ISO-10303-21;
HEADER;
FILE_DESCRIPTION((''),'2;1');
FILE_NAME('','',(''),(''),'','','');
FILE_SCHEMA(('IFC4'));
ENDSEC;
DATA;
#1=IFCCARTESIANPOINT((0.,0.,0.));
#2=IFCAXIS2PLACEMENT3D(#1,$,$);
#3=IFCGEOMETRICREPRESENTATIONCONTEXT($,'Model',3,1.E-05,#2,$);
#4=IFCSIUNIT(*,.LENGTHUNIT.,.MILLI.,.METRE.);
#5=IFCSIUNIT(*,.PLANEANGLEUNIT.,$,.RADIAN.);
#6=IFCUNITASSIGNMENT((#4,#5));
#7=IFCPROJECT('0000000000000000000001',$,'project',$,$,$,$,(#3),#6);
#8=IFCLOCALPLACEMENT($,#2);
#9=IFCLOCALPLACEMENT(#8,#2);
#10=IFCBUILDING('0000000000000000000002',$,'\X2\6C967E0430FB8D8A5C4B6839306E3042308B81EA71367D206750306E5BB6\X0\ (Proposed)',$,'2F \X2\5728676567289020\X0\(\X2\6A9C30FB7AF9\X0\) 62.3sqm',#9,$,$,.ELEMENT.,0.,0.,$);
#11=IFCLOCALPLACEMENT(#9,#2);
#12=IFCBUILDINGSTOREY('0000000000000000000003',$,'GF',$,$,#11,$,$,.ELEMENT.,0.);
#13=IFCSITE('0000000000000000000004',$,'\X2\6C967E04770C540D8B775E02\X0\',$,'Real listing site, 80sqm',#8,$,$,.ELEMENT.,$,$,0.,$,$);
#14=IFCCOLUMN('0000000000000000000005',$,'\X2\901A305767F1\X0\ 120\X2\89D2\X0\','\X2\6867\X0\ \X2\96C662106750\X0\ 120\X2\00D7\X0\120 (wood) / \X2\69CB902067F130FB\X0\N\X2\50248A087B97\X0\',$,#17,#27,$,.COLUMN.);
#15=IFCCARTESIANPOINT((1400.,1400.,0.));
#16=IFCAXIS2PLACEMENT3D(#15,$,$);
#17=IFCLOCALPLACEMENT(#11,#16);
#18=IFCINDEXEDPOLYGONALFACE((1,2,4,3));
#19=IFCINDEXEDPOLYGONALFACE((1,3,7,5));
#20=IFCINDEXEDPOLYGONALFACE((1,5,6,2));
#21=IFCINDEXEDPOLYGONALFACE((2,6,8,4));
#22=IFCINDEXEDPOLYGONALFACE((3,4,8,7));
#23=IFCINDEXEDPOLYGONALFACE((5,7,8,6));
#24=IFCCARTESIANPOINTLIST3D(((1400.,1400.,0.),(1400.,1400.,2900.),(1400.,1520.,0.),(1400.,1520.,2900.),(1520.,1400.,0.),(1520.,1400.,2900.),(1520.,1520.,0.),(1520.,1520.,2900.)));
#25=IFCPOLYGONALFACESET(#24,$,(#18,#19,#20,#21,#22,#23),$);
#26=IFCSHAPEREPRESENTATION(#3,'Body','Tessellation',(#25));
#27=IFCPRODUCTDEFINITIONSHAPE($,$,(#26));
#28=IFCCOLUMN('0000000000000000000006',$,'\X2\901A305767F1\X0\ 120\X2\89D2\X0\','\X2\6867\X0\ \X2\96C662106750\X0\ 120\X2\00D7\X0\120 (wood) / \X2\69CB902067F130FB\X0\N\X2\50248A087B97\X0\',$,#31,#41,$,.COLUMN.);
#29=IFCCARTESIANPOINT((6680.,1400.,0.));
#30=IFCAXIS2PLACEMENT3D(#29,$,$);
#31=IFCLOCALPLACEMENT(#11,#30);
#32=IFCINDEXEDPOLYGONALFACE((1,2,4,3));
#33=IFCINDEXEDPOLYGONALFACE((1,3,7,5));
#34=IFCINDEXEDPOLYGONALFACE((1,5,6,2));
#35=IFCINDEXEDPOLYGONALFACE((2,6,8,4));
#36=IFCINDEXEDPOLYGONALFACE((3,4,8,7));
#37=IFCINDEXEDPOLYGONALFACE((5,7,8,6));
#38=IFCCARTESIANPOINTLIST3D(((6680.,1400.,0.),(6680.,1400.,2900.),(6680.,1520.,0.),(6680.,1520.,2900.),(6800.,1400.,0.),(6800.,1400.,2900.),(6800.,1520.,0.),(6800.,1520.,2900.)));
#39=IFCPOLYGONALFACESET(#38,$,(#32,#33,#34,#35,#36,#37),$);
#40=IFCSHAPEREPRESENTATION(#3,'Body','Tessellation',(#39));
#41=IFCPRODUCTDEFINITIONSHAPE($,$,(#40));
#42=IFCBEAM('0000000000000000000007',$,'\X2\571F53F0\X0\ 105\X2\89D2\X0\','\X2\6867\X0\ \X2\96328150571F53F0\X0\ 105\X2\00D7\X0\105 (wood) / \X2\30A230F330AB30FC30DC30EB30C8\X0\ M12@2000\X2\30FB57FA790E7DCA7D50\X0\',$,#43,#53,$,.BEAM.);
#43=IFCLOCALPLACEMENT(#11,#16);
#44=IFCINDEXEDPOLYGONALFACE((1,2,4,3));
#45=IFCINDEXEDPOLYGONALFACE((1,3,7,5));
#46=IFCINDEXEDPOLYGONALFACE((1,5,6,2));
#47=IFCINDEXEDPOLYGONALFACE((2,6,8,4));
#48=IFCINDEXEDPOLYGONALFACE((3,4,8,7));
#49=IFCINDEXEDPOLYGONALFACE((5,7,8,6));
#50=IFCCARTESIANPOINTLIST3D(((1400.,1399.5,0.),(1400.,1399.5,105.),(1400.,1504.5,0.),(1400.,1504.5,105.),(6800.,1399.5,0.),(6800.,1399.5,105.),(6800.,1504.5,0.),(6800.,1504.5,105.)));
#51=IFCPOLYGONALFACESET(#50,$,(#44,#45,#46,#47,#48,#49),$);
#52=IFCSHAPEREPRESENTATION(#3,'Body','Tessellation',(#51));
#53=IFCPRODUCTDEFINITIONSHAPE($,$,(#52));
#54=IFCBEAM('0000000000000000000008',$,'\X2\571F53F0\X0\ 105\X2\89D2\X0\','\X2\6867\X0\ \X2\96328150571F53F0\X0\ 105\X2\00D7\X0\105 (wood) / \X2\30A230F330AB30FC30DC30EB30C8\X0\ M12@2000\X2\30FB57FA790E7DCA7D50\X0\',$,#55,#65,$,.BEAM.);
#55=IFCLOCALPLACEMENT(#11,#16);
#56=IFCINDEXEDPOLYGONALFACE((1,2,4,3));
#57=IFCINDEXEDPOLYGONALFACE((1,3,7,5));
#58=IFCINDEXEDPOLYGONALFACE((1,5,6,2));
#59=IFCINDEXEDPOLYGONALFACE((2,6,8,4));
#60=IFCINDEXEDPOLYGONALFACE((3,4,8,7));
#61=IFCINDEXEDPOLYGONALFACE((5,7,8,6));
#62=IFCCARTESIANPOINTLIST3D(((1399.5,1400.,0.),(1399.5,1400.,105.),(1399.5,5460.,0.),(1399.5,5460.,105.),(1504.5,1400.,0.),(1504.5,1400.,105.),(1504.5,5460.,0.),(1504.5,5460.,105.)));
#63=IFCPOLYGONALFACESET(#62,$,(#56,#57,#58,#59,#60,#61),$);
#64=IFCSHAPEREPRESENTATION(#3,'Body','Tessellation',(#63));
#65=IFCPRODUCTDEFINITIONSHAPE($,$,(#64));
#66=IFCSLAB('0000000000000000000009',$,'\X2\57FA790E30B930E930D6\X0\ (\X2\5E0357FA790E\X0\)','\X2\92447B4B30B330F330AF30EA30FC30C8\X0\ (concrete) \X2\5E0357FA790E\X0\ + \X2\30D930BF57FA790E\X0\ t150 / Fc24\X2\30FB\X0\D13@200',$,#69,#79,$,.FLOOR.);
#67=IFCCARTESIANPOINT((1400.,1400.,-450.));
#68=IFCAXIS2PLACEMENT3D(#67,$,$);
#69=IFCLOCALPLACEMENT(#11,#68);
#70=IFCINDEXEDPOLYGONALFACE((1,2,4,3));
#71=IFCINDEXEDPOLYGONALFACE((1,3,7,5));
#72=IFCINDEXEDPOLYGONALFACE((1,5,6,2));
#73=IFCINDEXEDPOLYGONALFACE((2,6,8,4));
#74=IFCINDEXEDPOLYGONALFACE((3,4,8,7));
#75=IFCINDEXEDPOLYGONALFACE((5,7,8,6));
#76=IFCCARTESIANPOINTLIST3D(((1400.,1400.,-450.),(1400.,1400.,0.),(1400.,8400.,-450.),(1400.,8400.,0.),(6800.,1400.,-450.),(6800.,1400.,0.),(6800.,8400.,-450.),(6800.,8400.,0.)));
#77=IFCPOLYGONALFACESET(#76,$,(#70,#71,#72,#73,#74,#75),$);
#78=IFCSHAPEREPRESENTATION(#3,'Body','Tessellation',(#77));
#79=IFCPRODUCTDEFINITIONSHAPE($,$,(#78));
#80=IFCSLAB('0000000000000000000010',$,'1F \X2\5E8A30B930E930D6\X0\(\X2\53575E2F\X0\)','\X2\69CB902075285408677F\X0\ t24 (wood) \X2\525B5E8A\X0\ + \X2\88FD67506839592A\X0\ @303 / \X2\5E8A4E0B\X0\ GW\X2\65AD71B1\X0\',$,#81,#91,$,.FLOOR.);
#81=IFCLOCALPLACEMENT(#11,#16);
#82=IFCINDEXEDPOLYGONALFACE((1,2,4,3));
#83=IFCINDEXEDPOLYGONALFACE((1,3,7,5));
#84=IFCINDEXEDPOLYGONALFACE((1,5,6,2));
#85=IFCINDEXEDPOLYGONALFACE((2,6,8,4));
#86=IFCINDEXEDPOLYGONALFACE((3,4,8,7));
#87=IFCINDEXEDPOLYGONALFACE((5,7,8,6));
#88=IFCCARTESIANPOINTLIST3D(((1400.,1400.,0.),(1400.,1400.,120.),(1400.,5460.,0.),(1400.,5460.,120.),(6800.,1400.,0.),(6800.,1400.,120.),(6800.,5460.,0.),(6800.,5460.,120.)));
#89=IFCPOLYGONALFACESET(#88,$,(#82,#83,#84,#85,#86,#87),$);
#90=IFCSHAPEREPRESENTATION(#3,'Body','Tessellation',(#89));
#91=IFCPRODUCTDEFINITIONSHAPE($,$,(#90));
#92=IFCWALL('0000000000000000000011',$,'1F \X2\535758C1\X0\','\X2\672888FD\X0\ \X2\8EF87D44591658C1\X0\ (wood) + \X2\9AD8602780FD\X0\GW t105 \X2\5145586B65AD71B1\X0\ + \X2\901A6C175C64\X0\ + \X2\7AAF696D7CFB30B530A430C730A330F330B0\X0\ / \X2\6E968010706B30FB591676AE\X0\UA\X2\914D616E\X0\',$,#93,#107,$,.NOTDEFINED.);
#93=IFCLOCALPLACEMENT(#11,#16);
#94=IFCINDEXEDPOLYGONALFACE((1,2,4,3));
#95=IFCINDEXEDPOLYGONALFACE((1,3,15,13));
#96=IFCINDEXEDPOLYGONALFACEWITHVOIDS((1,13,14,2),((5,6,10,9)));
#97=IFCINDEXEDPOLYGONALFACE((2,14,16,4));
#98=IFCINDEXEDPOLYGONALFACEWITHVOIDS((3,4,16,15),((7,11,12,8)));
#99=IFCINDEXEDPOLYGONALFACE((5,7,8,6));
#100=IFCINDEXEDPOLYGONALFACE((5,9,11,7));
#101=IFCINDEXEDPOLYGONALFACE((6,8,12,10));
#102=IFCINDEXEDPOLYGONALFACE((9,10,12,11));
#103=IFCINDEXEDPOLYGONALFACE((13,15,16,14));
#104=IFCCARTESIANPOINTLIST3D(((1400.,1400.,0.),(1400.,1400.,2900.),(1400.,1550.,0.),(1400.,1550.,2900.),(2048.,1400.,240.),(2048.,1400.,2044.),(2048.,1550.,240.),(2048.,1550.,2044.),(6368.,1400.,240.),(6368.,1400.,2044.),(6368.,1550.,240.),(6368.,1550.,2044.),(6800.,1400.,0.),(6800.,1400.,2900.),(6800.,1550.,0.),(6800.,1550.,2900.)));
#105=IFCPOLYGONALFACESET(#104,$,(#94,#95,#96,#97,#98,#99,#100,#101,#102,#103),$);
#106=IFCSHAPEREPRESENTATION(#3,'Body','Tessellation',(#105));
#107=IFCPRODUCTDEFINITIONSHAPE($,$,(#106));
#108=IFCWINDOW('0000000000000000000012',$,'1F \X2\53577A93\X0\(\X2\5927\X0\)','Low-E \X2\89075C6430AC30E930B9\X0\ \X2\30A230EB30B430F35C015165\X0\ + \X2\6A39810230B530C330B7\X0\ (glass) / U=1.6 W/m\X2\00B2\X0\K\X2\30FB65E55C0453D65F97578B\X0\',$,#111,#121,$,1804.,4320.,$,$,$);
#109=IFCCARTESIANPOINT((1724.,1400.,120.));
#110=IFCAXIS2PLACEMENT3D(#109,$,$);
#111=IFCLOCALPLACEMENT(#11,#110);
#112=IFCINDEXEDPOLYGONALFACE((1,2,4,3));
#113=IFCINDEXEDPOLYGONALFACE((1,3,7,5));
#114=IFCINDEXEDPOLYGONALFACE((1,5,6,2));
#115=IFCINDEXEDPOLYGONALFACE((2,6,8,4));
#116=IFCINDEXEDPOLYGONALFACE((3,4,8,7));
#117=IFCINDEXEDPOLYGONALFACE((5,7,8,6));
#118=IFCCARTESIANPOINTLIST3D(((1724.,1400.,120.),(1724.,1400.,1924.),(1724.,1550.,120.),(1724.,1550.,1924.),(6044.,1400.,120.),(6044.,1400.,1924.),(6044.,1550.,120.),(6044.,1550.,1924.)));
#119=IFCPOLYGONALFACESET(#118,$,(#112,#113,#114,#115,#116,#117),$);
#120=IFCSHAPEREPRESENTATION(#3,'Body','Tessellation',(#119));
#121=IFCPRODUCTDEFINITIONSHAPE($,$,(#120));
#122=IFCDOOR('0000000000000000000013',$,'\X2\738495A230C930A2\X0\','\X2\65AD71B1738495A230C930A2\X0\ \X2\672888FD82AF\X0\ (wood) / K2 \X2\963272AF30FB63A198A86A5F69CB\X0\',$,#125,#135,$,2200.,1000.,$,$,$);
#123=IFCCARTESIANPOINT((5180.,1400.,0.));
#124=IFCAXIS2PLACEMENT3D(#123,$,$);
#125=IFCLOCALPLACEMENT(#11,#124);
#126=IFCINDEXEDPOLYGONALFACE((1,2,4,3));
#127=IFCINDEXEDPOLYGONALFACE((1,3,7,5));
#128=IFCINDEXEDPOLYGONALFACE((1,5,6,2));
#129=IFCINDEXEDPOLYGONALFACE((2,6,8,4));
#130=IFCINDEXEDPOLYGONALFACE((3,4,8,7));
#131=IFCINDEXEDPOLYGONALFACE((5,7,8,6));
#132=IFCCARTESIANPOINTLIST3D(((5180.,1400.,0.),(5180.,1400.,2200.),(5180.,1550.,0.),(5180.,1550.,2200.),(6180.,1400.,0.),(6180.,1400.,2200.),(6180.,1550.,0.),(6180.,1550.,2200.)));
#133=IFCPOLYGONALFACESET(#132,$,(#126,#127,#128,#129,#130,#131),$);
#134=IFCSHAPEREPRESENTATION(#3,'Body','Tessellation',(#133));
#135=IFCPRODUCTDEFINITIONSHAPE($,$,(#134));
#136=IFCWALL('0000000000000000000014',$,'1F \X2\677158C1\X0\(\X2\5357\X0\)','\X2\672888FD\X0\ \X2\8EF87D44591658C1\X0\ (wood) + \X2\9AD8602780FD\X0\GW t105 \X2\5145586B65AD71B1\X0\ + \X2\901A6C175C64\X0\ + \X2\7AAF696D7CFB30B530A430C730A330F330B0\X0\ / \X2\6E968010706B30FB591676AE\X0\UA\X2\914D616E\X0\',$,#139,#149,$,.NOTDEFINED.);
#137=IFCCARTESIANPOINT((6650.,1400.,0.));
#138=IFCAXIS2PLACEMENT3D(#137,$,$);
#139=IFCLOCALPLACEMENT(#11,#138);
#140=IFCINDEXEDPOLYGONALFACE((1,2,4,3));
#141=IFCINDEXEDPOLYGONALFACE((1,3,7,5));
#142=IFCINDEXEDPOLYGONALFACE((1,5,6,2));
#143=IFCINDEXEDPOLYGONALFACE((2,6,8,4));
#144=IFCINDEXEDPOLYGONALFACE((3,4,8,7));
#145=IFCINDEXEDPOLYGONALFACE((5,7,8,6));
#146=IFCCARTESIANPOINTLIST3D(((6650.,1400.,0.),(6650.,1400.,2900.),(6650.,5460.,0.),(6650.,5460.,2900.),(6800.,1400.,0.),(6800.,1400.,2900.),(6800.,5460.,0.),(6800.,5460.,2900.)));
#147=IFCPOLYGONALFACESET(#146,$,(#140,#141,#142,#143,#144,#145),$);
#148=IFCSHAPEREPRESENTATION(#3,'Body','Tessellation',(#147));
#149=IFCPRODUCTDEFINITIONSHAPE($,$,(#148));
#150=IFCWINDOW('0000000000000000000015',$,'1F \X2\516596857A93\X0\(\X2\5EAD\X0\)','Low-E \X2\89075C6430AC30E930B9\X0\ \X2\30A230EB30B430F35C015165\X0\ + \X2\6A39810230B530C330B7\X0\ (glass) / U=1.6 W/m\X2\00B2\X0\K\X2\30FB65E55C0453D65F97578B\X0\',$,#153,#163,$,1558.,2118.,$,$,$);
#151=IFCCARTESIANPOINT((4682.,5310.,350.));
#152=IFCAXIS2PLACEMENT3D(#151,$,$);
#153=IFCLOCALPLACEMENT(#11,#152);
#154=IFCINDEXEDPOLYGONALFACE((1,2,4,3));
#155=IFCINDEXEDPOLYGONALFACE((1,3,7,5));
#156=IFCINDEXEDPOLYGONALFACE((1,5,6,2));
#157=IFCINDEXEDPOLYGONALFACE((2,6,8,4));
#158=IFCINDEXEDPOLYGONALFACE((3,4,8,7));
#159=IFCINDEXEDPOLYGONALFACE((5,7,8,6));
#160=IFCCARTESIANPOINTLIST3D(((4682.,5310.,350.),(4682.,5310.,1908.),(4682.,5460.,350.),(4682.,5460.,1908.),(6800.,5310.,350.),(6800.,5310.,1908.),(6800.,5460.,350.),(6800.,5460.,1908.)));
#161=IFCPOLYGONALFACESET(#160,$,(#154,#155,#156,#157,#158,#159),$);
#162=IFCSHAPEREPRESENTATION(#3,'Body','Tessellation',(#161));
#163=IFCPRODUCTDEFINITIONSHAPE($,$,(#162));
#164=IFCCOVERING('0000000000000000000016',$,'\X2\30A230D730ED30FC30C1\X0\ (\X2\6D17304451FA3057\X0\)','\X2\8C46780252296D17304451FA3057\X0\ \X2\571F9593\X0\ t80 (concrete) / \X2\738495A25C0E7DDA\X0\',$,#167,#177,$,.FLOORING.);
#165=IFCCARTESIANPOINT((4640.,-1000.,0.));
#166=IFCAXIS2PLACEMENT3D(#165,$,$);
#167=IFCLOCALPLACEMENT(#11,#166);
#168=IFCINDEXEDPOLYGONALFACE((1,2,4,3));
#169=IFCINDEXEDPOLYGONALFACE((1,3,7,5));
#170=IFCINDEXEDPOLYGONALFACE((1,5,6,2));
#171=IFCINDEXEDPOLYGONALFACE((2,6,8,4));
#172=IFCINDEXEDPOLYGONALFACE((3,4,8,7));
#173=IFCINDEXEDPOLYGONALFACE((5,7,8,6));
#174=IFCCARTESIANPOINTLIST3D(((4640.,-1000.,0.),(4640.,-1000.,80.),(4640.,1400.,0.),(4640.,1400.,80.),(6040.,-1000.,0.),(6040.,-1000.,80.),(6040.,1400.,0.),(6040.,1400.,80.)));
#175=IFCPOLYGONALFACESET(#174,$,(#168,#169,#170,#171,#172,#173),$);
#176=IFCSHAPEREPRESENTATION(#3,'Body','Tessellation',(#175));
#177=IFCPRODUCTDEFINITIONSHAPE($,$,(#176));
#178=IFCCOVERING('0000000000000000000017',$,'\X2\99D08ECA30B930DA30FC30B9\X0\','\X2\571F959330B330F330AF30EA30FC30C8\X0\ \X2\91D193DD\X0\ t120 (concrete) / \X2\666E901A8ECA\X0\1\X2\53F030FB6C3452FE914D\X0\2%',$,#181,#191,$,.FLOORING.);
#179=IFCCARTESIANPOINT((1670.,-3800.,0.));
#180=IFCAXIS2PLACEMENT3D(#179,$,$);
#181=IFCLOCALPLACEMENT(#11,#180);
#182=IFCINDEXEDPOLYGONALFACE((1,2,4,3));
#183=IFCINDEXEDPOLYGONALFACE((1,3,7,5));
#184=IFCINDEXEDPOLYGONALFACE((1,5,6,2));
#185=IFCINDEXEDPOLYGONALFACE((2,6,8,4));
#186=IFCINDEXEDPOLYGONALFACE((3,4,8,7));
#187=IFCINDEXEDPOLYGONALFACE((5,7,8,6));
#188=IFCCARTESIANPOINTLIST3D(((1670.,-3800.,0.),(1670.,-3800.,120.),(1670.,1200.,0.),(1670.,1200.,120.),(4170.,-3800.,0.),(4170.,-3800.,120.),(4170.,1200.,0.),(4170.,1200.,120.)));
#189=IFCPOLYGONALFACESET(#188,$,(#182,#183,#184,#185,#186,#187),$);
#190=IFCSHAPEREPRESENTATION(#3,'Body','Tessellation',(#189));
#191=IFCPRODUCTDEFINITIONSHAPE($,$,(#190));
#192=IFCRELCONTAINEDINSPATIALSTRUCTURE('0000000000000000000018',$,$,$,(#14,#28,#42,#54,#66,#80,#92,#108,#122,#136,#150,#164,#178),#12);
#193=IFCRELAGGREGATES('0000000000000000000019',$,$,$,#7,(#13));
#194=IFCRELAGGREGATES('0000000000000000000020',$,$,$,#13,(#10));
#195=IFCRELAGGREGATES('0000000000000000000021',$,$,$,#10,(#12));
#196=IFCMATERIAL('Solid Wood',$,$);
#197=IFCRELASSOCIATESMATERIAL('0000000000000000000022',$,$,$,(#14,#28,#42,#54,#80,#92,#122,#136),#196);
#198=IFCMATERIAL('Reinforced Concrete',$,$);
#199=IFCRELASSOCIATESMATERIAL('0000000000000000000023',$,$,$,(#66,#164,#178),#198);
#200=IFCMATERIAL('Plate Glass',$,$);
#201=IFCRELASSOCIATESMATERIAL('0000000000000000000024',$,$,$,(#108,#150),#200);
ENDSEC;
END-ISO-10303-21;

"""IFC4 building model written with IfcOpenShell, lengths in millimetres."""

from ifc_helpers import new_model, si_unit, frame, frame_2d, origin, place, context, project, spatial, rectangle, extrude, material, element, fill, save


model = new_model("IFC4")

# Units and contexts
model_context = context("Model", 3, precision=1e-05, world=origin())
ifc_project = project(units=[si_unit("LENGTHUNIT", "METRE", prefix="MILLI"), si_unit("PLANEANGLEUNIT", "RADIAN")], contexts=[model_context])

# Site, building, storey
site_placement = place(None, origin())
site = spatial("IfcSite", under=ifc_project, at=site_placement, Name="沖縄県名護市", ObjectType="Real listing site, 80sqm", CompositionType="ELEMENT", RefElevation=0.0)
building_placement = place(site_placement, origin())
building = spatial("IfcBuilding", under=site, at=building_placement, Name="沖縄・越屋根のある自然素材の家 (Proposed)", ObjectType="2F 在来木造(檜・竹) 62.3sqm", CompositionType="ELEMENT", ElevationOfRefHeight=0.0, ElevationOfTerrain=0.0)
storey_placement = place(building_placement, origin())
storey = spatial("IfcBuildingStorey", under=building, at=storey_placement, Name="GF", CompositionType="ELEMENT", Elevation=0.0)

# Columns
ifc_material_1 = material(Name="Solid Wood")
column_1_placement = place(storey_placement, frame((1400.0, 1400.0, 0.0)))
element("IfcColumn", 1, at=column_1_placement, inside=storey, material=ifc_material_1, Name="通し柱 120角", Description="桧 集成材 120×120 (wood) / 構造柱・N値計算", PredefinedType="COLUMN", context=model_context, shape_type="SweptSolid", body=[
    extrude(rectangle(XDim=120.0, YDim=120.0, at=frame_2d((60.0, 60.0))), frame((1400.0, 1400.0, 0.0)), (0.0, 0.0, 1.0), 2900.0),
])
column_2_placement = place(storey_placement, frame((6680.0, 1400.0, 0.0)))
element("IfcColumn", 2, at=column_2_placement, inside=storey, material=ifc_material_1, Name="通し柱 120角", Description="桧 集成材 120×120 (wood) / 構造柱・N値計算", PredefinedType="COLUMN", context=model_context, shape_type="SweptSolid", body=[
    extrude(rectangle(XDim=120.0, YDim=120.0, at=frame_2d((60.0, 60.0))), frame((6680.0, 1400.0, 0.0)), (0.0, 0.0, 1.0), 2900.0),
])

# Beams
beam_1_placement = place(storey_placement, frame((1400.0, 1400.0, 0.0)))
element("IfcBeam", 3, at=beam_1_placement, inside=storey, material=ifc_material_1, Name="土台 105角", Description="桧 防腐土台 105×105 (wood) / アンカーボルト M12@2000・基礎緊結", PredefinedType="BEAM", context=model_context, shape_type="SweptSolid", body=[
    extrude(rectangle(XDim=5400.0, YDim=105.0, at=frame_2d((2700.0, 52.0))), frame((1400.0, 1400.0, 0.0)), (0.0, 0.0, 1.0), 105.0),
])
beam_2_placement = place(storey_placement, frame((1400.0, 1400.0, 0.0)))
element("IfcBeam", 4, at=beam_2_placement, inside=storey, material=ifc_material_1, Name="土台 105角", Description="桧 防腐土台 105×105 (wood) / アンカーボルト M12@2000・基礎緊結", PredefinedType="BEAM", context=model_context, shape_type="SweptSolid", body=[
    extrude(rectangle(XDim=105.0, YDim=4060.0, at=frame_2d((52.0, 2030.0))), frame((1400.0, 1400.0, 0.0)), (0.0, 0.0, 1.0), 105.0),
])

# Slabs
ifc_material_2 = material(Name="Reinforced Concrete")
slab_1_placement = place(storey_placement, frame((1400.0, 1400.0, -450.0)))
element("IfcSlab", 5, at=slab_1_placement, inside=storey, material=ifc_material_2, Name="基礎スラブ (布基礎)", Description="鉄筋コンクリート (concrete) 布基礎 + ベタ基礎 t150 / Fc24・D13@200", PredefinedType="FLOOR", context=model_context, shape_type="SweptSolid", body=[
    extrude(rectangle(XDim=5400.0, YDim=7000.0, at=frame_2d((2700.0, 3500.0))), frame((1400.0, 1400.0, -450.0)), (0.0, 0.0, 1.0), 450.0),
])
slab_2_placement = place(storey_placement, frame((1400.0, 1400.0, 0.0)))
element("IfcSlab", 6, at=slab_2_placement, inside=storey, material=ifc_material_1, Name="1F 床スラブ(南帯)", Description="構造用合板 t24 (wood) 剛床 + 製材根太 @303 / 床下 GW断熱", PredefinedType="FLOOR", context=model_context, shape_type="SweptSolid", body=[
    extrude(rectangle(XDim=5400.0, YDim=4060.0, at=frame_2d((2700.0, 2030.0))), frame((1400.0, 1400.0, 0.0)), (0.0, 0.0, 1.0), 120.0),
])

# Wall, openings, window, door
wall_1_placement = place(storey_placement, frame((1400.0, 1400.0, 0.0)))
wall_1 = element("IfcWall", 7, at=wall_1_placement, inside=storey, material=ifc_material_1, Name="1F 南壁", Description="木製 軸組外壁 (wood) + 高性能GW t105 充填断熱 + 通気層 + 窯業系サイディング / 準耐火・外皮UA配慮", PredefinedType="NOTDEFINED", context=model_context, shape_type="SweptSolid", body=[
    extrude(rectangle(XDim=5400.0, YDim=150.0, at=frame_2d((2700.0, 75.0))), frame((1400.0, 1400.0, 0.0)), (0.0, 0.0, 1.0), 2900.0),
])
opening_1_placement = place(storey_placement, frame((1724.0, 1400.0, 120.0)))
opening_1 = element("IfcOpeningElement", 8, at=opening_1_placement, cuts=wall_1, PredefinedType="NOTDEFINED", context=model_context, shape_type="SweptSolid", body=[
    extrude(rectangle(XDim=4320.0, YDim=150.0, at=frame_2d((2160.0, 75.0))), frame((1724.0, 1400.0, 120.0)), (0.0, 0.0, 1.0), 1804.0),
])
opening_2_placement = place(storey_placement, frame((5180.0, 1400.0, 0.0)))
opening_2 = element("IfcOpeningElement", 9, at=opening_2_placement, cuts=wall_1, PredefinedType="NOTDEFINED", context=model_context, shape_type="SweptSolid", body=[
    extrude(rectangle(XDim=1000.0, YDim=150.0, at=frame_2d((500.0, 75.0))), frame((5180.0, 1400.0, 0.0)), (0.0, 0.0, 1.0), 2200.0),
])
ifc_material_3 = material(Name="Plate Glass")
window_1_placement = place(storey_placement, frame((1724.0, 1400.0, 120.0)))
window_1 = element("IfcWindow", 10, at=window_1_placement, inside=storey, material=ifc_material_3, Name="1F 南窓(大)", Description="Low-E 複層ガラス アルゴン封入 + 樹脂サッシ (glass) / U=1.6 W/m²K・日射取得型", OverallHeight=1804.0, OverallWidth=4320.0, context=model_context, shape_type="SweptSolid", body=[
    extrude(rectangle(XDim=4320.0, YDim=150.0, at=frame_2d((2160.0, 75.0))), frame((1724.0, 1400.0, 120.0)), (0.0, 0.0, 1.0), 1804.0),
])
fill(opening_1, window_1)
door_1_placement = place(storey_placement, frame((5180.0, 1400.0, 0.0)))
door_1 = element("IfcDoor", 11, at=door_1_placement, inside=storey, material=ifc_material_1, Name="玄関ドア", Description="断熱玄関ドア 木製芯 (wood) / K2 防犯・採風機構", OverallHeight=2200.0, OverallWidth=1000.0, context=model_context, shape_type="SweptSolid", body=[
    extrude(rectangle(XDim=1000.0, YDim=150.0, at=frame_2d((500.0, 75.0))), frame((5180.0, 1400.0, 0.0)), (0.0, 0.0, 1.0), 2200.0),
])
fill(opening_2, door_1)

# Wall, opening, window
wall_2_placement = place(storey_placement, frame((6650.0, 1400.0, 0.0)))
wall_2 = element("IfcWall", 12, at=wall_2_placement, inside=storey, material=ifc_material_1, Name="1F 東壁(南)", Description="木製 軸組外壁 (wood) + 高性能GW t105 充填断熱 + 通気層 + 窯業系サイディング / 準耐火・外皮UA配慮", PredefinedType="NOTDEFINED", context=model_context, shape_type="SweptSolid", body=[
    extrude(rectangle(XDim=150.0, YDim=4060.0, at=frame_2d((75.0, 2030.0))), frame((6650.0, 1400.0, 0.0)), (0.0, 0.0, 1.0), 2900.0),
])
opening_3_placement = place(storey_placement, frame((4682.0, 5310.0, 350.0)))
opening_3 = element("IfcOpeningElement", 13, at=opening_3_placement, cuts=wall_2, PredefinedType="NOTDEFINED", context=model_context, shape_type="SweptSolid", body=[
    extrude(rectangle(XDim=2118.0, YDim=150.0, at=frame_2d((1059.0, 75.0))), frame((4682.0, 5310.0, 350.0)), (0.0, 0.0, 1.0), 1558.0),
])
window_2_placement = place(storey_placement, frame((4682.0, 5310.0, 350.0)))
window_2 = element("IfcWindow", 14, at=window_2_placement, inside=storey, material=ifc_material_3, Name="1F 入隅窓(庭)", Description="Low-E 複層ガラス アルゴン封入 + 樹脂サッシ (glass) / U=1.6 W/m²K・日射取得型", OverallHeight=1558.0, OverallWidth=2118.0, context=model_context, shape_type="SweptSolid", body=[
    extrude(rectangle(XDim=2118.0, YDim=150.0, at=frame_2d((1059.0, 75.0))), frame((4682.0, 5310.0, 350.0)), (0.0, 0.0, 1.0), 1558.0),
])
fill(opening_3, window_2)

# Coverings
covering_1_placement = place(storey_placement, frame((4640.0, -1000.0, 0.0)))
element("IfcCovering", 15, at=covering_1_placement, inside=storey, material=ifc_material_2, Name="アプローチ (洗い出し)", Description="豆砂利洗い出し 土間 t80 (concrete) / 玄関導線", PredefinedType="FLOORING", context=model_context, shape_type="SweptSolid", body=[
    extrude(rectangle(XDim=1400.0, YDim=2400.0, at=frame_2d((700.0, 1200.0))), frame((4640.0, -1000.0, 0.0)), (0.0, 0.0, 1.0), 80.0),
])
covering_2_placement = place(storey_placement, frame((1670.0, -3800.0, 0.0)))
element("IfcCovering", 16, at=covering_2_placement, inside=storey, material=ifc_material_2, Name="駐車スペース", Description="土間コンクリート 金鏝 t120 (concrete) / 普通車1台・水勾配2%", PredefinedType="FLOORING", context=model_context, shape_type="SweptSolid", body=[
    extrude(rectangle(XDim=2500.0, YDim=5000.0, at=frame_2d((1250.0, 2500.0))), frame((1670.0, -3800.0, 0.0)), (0.0, 0.0, 1.0), 120.0),
])

save(model, "model.ifc")
